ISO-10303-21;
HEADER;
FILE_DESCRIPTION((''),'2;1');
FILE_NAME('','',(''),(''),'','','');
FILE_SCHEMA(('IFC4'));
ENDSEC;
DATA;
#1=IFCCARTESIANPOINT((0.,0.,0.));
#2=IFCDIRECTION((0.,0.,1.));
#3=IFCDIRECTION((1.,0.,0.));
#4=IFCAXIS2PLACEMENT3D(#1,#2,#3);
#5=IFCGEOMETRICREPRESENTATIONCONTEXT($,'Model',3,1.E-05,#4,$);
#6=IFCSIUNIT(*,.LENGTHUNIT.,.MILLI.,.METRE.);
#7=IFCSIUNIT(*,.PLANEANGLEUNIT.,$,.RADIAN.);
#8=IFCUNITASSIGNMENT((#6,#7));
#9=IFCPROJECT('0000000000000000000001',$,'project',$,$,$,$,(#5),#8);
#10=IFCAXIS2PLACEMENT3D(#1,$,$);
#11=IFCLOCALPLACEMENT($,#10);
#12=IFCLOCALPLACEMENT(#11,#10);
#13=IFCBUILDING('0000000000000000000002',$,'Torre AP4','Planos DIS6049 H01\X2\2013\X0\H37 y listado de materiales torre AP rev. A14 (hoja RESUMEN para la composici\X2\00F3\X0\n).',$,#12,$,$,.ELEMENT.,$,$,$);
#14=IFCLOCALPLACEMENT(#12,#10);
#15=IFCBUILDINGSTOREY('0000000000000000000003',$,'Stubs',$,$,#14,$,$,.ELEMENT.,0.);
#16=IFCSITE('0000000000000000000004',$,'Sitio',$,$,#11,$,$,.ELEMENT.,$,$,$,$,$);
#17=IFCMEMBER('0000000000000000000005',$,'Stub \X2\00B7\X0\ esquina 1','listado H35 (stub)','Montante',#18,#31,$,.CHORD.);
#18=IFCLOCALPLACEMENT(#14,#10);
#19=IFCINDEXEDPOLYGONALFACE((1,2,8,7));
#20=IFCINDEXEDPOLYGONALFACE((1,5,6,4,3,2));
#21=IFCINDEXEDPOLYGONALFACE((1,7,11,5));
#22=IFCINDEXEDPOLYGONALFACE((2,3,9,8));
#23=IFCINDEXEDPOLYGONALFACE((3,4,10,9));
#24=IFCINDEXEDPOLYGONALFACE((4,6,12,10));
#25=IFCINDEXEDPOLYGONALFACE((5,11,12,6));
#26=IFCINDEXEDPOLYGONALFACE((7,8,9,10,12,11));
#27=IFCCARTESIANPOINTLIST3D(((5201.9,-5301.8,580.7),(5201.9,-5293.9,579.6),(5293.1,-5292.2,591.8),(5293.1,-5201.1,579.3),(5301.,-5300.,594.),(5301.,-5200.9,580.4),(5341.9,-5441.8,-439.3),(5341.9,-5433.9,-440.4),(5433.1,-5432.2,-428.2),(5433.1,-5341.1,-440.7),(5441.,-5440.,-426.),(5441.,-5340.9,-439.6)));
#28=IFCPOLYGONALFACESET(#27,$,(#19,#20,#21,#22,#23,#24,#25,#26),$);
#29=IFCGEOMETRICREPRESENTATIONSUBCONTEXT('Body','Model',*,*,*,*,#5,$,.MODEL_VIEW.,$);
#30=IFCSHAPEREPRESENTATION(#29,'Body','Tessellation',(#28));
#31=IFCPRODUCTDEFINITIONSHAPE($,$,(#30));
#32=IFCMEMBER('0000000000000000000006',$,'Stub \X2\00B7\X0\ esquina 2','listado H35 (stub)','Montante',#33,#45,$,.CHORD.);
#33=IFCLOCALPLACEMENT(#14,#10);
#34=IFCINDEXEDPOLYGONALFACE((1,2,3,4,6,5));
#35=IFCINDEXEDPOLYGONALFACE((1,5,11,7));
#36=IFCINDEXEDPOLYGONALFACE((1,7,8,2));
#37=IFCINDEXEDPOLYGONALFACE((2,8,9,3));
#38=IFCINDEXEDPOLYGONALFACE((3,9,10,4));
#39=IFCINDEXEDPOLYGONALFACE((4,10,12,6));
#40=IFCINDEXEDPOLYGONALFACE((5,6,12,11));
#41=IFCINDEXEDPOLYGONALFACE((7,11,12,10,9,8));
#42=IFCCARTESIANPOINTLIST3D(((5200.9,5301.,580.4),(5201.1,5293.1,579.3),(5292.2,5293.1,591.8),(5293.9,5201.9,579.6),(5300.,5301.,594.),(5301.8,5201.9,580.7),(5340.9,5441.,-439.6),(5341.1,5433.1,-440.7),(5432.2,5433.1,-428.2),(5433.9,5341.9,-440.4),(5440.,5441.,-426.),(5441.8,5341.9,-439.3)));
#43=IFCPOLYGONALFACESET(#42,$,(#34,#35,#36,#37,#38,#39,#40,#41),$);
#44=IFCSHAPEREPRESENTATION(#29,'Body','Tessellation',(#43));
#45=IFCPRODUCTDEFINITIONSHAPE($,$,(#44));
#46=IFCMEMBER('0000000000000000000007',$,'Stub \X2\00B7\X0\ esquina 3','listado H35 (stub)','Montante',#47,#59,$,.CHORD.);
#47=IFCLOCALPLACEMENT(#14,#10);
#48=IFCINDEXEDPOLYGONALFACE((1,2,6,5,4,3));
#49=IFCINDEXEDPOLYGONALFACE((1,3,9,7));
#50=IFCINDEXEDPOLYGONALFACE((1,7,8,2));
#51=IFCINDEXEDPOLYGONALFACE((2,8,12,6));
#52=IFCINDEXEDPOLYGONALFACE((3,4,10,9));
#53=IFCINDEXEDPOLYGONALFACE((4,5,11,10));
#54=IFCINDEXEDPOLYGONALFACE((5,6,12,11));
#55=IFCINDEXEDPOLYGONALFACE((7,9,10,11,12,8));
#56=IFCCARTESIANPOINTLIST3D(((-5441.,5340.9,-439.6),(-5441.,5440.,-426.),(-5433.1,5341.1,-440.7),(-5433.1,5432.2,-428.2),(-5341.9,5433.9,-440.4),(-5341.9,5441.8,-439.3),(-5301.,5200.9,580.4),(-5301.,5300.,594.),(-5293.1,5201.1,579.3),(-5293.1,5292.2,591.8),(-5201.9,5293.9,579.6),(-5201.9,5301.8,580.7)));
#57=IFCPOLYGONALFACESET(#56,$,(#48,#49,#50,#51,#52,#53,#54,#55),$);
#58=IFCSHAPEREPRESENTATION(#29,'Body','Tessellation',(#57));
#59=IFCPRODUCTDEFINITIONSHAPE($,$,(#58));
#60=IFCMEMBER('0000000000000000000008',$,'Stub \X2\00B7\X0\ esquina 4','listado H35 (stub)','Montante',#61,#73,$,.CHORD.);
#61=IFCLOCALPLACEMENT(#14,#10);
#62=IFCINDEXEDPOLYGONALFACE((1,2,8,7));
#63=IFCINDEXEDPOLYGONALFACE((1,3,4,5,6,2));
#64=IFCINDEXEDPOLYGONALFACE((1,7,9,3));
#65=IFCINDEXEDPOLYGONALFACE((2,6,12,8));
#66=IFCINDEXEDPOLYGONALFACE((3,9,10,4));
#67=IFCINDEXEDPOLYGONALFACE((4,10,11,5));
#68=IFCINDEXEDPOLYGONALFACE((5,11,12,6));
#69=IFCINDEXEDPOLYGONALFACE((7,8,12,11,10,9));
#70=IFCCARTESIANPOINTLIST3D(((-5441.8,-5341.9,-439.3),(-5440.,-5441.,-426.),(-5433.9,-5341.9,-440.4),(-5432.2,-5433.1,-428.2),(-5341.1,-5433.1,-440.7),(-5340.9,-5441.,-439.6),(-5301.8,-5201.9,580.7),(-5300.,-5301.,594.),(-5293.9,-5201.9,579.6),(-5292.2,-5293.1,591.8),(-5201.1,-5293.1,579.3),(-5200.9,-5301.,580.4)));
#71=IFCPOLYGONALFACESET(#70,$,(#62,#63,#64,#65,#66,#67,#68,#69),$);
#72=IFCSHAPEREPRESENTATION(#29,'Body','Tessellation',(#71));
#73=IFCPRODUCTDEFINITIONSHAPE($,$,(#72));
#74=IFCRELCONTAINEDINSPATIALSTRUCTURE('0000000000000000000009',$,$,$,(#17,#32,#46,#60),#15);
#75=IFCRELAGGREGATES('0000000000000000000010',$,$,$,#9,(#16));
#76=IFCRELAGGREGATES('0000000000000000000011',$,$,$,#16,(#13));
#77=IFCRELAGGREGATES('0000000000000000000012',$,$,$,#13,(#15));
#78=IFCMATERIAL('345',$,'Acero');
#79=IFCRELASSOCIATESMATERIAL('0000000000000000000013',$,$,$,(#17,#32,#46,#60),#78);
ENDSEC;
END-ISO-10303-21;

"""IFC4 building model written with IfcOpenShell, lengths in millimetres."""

from ifc_helpers import new_model, si_unit, frame, frame_2d, origin, origin_with_axes, place, context, subcontext, project, spatial, l_section, extrude, material, element, save


model = new_model("IFC4")

# Units and contexts
model_context = context("Model", 3, precision=1e-05, world=origin_with_axes())
body_context = subcontext(model_context, "Body", "Model", "MODEL_VIEW")
ifc_project = project(units=[si_unit("LENGTHUNIT", "METRE", prefix="MILLI"), si_unit("PLANEANGLEUNIT", "RADIAN")], contexts=[model_context])

# Site, building, storey
site_placement = place(None, origin())
site = spatial("IfcSite", under=ifc_project, at=site_placement, Name="Sitio", CompositionType="ELEMENT")
building_placement = place(site_placement, origin())
building = spatial("IfcBuilding", under=site, at=building_placement, Name="Torre AP4", Description="Planos DIS6049 H01–H37 y listado de materiales torre AP rev. A14 (hoja RESUMEN para la composición).", CompositionType="ELEMENT")
storey_placement = place(building_placement, origin())
storey = spatial("IfcBuildingStorey", under=building, at=storey_placement, Name="Stubs", CompositionType="ELEMENT", Elevation=0.0)

# Members
ifc_material = material(Name="345", Category="Acero")
for number, where, z_axis, x_axis, name in (
    (1, (5301.0, -5300.0, 594.0), (0.13474, -0.13474, -0.981677), (-0.990881, -0.018322, -0.133488), "Stub · esquina 1"),
    (2, (5300.0, 5301.0, 594.0), (0.13474, 0.13474, -0.981677), (0.018322, -0.990881, -0.133488), "Stub · esquina 2"),
    (3, (-5301.0, 5300.0, 594.0), (-0.13474, 0.13474, -0.981677), (0.990881, 0.018322, -0.133488), "Stub · esquina 3"),
    (4, (-5300.0, -5301.0, 594.0), (-0.13474, -0.13474, -0.981677), (-0.018322, 0.990881, -0.133488), "Stub · esquina 4"),
):
    element("IfcMember", number, at=place(storey_placement, frame(where, z_axis=z_axis, x_axis=x_axis)), inside=storey, material=ifc_material, Name=name, Description="listado H35 (stub)", ObjectType="Montante", PredefinedType="CHORD", context=body_context, shape_type="SweptSolid", body=[
        extrude(l_section(Depth=100.0, Width=100.0, Thickness=8.0, at=frame_2d((50.0, 50.0))), None, (0.0, 0.0, 1.0), 1039.0),
    ])

save(model, "model.ifc")
